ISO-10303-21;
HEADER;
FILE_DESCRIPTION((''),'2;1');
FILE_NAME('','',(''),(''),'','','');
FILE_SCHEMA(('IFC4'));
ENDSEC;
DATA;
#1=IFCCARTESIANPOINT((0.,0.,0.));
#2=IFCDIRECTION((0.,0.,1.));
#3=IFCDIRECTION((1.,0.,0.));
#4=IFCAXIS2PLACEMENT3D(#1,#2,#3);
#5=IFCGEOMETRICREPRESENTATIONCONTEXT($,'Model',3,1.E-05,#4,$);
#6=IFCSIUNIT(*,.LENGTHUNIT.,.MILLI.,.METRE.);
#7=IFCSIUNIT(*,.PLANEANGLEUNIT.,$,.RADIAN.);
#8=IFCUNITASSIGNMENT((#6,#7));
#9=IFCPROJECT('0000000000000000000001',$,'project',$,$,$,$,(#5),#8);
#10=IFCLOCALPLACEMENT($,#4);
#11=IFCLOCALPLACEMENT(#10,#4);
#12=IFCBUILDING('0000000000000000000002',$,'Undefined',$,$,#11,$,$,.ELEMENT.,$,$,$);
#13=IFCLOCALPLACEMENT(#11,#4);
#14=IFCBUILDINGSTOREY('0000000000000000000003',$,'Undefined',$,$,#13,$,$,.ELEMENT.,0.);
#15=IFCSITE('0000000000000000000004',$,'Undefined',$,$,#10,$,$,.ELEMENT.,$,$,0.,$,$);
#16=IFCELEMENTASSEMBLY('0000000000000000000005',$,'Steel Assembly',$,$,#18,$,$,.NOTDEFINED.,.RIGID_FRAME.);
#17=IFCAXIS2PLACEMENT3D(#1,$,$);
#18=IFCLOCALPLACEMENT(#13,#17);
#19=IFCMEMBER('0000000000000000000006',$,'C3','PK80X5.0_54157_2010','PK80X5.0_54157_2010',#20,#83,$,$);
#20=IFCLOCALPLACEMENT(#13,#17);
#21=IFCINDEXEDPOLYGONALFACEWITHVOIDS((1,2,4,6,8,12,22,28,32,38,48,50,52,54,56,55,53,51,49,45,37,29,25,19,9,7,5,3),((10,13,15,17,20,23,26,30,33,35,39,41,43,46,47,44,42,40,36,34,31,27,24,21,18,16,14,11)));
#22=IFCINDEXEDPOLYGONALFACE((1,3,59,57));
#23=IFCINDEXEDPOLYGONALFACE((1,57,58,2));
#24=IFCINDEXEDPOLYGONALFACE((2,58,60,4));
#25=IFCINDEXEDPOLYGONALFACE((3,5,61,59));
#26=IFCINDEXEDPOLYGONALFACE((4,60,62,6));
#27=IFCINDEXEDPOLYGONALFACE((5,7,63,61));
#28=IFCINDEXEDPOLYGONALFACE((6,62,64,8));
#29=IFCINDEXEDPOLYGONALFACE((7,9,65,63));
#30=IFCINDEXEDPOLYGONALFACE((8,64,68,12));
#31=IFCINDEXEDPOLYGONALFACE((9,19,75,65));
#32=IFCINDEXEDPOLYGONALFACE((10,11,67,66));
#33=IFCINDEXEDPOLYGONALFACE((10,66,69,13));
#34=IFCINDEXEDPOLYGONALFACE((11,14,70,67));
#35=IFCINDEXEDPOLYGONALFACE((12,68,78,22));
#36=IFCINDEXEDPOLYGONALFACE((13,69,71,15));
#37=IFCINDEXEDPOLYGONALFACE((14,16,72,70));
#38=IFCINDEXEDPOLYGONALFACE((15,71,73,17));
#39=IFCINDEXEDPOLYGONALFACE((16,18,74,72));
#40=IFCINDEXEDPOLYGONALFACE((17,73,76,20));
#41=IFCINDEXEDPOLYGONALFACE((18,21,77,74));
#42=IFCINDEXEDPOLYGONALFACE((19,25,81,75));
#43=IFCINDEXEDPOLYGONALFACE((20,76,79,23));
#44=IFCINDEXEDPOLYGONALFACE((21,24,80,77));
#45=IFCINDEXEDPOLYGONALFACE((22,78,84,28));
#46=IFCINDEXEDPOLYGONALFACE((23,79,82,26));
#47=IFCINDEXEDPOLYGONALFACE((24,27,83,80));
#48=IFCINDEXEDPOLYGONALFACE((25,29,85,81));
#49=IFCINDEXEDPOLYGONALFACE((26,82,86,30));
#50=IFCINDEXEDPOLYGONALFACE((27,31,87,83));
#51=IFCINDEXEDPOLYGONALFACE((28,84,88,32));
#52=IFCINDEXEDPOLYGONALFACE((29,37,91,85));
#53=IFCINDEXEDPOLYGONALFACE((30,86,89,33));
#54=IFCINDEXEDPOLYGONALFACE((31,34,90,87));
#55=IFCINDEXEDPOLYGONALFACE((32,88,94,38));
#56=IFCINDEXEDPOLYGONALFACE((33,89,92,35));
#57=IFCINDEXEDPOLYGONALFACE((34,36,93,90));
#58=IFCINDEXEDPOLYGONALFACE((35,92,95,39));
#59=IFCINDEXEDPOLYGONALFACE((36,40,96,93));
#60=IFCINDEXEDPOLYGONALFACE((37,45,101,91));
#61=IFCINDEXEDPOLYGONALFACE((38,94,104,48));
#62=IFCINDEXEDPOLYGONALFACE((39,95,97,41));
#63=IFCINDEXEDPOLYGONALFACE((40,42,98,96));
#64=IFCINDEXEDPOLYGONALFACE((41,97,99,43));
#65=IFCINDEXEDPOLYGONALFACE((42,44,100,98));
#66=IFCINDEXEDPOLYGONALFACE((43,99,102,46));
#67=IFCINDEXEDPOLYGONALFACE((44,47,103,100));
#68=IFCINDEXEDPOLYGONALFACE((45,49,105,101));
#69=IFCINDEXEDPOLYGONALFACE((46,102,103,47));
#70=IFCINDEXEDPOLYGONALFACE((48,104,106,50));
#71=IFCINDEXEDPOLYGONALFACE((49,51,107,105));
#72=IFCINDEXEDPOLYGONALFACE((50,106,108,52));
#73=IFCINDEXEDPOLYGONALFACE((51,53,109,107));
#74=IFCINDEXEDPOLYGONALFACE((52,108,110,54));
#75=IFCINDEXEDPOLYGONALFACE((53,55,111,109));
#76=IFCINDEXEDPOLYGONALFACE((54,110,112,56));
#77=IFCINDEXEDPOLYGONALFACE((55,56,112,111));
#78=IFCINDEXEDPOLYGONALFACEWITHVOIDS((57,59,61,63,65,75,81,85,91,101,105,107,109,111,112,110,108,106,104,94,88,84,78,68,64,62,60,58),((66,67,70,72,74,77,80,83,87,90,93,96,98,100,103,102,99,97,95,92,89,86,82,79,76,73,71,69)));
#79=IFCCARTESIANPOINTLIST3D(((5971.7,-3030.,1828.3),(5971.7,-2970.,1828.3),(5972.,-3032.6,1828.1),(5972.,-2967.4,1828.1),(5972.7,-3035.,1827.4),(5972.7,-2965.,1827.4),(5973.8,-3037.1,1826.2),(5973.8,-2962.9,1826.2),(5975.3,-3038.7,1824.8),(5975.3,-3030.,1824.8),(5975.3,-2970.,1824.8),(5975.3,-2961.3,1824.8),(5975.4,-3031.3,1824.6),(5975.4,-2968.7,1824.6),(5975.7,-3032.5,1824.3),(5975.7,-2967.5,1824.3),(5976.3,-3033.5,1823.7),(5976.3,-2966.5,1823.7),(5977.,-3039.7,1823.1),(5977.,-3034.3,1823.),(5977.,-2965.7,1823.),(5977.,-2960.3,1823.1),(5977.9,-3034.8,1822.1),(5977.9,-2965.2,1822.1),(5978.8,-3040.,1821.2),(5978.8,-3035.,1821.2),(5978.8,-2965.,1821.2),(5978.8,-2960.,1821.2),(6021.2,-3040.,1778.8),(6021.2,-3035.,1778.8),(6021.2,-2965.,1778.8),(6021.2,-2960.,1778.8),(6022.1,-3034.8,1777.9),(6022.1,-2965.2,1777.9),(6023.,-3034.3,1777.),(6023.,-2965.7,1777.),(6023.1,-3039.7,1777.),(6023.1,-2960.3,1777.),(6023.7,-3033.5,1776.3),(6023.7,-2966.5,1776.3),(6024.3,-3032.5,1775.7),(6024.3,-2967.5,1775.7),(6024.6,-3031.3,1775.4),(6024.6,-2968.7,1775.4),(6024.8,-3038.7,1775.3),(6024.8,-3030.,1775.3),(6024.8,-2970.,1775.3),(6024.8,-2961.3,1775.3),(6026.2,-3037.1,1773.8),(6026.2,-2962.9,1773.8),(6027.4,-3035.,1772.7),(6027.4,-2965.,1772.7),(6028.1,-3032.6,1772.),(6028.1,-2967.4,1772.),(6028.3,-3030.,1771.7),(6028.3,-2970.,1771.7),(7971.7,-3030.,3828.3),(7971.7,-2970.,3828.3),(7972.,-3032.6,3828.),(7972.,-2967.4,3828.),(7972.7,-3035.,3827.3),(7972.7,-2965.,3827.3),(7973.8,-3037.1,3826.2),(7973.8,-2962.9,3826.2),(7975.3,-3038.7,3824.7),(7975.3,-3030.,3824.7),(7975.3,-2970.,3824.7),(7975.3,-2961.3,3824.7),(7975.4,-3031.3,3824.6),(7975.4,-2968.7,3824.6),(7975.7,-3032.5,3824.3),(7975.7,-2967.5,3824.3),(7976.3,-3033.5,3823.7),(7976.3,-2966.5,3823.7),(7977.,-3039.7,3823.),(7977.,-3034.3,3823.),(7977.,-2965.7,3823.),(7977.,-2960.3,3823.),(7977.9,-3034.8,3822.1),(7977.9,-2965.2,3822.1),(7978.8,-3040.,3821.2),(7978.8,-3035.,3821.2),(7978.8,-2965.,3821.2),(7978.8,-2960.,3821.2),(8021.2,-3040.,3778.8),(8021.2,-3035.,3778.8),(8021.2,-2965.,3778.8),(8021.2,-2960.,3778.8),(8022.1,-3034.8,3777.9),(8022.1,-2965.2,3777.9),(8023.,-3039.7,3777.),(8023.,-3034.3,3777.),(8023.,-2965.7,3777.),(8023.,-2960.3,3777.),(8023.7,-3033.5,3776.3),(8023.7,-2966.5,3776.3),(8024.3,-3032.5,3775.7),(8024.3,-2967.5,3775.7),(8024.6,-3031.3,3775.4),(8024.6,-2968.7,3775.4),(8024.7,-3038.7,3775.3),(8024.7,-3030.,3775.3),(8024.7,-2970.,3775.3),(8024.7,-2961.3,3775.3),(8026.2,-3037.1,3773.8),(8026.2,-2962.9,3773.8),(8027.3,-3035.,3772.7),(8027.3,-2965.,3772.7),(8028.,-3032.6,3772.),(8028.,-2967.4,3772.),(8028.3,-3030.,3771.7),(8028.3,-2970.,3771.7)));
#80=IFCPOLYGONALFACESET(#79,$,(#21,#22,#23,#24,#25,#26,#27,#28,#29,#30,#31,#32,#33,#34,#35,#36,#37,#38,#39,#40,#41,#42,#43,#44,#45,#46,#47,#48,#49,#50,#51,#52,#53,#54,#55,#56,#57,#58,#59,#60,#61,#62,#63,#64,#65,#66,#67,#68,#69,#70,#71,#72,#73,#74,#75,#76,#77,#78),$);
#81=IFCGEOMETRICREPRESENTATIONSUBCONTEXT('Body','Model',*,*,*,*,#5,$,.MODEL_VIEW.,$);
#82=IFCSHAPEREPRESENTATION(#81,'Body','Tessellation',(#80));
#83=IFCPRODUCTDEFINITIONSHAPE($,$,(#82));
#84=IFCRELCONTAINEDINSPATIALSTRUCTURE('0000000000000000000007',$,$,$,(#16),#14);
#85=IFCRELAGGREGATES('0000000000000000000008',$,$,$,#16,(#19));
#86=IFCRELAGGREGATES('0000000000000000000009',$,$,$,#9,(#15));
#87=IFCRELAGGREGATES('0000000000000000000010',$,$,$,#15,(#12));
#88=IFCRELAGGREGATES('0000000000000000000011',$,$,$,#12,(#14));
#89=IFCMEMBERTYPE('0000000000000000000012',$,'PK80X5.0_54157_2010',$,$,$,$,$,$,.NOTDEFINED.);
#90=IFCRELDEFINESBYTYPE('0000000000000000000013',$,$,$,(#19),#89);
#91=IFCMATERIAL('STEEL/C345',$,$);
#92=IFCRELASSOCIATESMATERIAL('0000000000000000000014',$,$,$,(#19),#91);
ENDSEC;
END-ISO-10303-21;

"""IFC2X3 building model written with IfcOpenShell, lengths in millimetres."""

from ifc_helpers import new_model, si_unit, frame, origin_with_axes, origin_2d_with_axis, place, context, subcontext, project, spatial, hollow_rectangle, extrude, material, type_object, element, aggregate, save


model = new_model("IFC2X3")

# Units and contexts
model_context = context("Model", 3, precision=1e-05, world=origin_with_axes())
body_context = subcontext(model_context, "Body", "Model", "MODEL_VIEW")
ifc_project = project(units=[si_unit("LENGTHUNIT", "METRE", prefix="MILLI"), si_unit("PLANEANGLEUNIT", "RADIAN")], contexts=[model_context])

# Site, building, storey
site_placement = place(None, origin_with_axes())
site = spatial("IfcSite", under=ifc_project, at=site_placement, Name="Undefined", CompositionType="ELEMENT", RefElevation=0.0)
building_placement = place(site_placement, origin_with_axes())
building = spatial("IfcBuilding", under=site, at=building_placement, Name="Undefined", CompositionType="ELEMENT")
storey_placement = place(building_placement, origin_with_axes())
storey = spatial("IfcBuildingStorey", under=building, at=storey_placement, Name="Undefined", CompositionType="ELEMENT", Elevation=0.0)

# Shared definitions
ifc_material_1 = material(Name="STEEL/C345")

# Element assembly, member
member_type_1 = type_object("IfcMemberType", Name="PK80X5.0_54157_2010", PredefinedType="NOTDEFINED")
assembly_1_placement = place(storey_placement, origin_with_axes())
assembly_1 = element("IfcElementAssembly", 1, at=assembly_1_placement, inside=storey, Name="Steel Assembly", AssemblyPlace="NOTDEFINED", PredefinedType="RIGID_FRAME")
member_1_placement = place(assembly_1_placement, frame((6000.0, -3000.0, 1800.0), z_axis=(-0.707107, 0.0, 0.707107), x_axis=(0.707107, 0.0, 0.707107)))
member_1 = element("IfcMember", 2, at=member_1_placement, type_object=member_type_1, material=ifc_material_1, Name="C3", Description="PK80X5.0_54157_2010", ObjectType="PK80X5.0_54157_2010", context=body_context, shape_type="SweptSolid", body=[
    extrude(hollow_rectangle(XDim=80.0, YDim=80.0, WallThickness=5.0, InnerFilletRadius=5.0, OuterFilletRadius=10.0, at=origin_2d_with_axis()), frame((2828.4, 0.0, 0.0), z_axis=(-1.0, 0.0, 0.0), x_axis=(0.0, -1.0, 0.0)), (0.0, 0.0, 1.0), 2828.4),
])
aggregate(assembly_1, [member_1])

save(model, "model.ifc")
